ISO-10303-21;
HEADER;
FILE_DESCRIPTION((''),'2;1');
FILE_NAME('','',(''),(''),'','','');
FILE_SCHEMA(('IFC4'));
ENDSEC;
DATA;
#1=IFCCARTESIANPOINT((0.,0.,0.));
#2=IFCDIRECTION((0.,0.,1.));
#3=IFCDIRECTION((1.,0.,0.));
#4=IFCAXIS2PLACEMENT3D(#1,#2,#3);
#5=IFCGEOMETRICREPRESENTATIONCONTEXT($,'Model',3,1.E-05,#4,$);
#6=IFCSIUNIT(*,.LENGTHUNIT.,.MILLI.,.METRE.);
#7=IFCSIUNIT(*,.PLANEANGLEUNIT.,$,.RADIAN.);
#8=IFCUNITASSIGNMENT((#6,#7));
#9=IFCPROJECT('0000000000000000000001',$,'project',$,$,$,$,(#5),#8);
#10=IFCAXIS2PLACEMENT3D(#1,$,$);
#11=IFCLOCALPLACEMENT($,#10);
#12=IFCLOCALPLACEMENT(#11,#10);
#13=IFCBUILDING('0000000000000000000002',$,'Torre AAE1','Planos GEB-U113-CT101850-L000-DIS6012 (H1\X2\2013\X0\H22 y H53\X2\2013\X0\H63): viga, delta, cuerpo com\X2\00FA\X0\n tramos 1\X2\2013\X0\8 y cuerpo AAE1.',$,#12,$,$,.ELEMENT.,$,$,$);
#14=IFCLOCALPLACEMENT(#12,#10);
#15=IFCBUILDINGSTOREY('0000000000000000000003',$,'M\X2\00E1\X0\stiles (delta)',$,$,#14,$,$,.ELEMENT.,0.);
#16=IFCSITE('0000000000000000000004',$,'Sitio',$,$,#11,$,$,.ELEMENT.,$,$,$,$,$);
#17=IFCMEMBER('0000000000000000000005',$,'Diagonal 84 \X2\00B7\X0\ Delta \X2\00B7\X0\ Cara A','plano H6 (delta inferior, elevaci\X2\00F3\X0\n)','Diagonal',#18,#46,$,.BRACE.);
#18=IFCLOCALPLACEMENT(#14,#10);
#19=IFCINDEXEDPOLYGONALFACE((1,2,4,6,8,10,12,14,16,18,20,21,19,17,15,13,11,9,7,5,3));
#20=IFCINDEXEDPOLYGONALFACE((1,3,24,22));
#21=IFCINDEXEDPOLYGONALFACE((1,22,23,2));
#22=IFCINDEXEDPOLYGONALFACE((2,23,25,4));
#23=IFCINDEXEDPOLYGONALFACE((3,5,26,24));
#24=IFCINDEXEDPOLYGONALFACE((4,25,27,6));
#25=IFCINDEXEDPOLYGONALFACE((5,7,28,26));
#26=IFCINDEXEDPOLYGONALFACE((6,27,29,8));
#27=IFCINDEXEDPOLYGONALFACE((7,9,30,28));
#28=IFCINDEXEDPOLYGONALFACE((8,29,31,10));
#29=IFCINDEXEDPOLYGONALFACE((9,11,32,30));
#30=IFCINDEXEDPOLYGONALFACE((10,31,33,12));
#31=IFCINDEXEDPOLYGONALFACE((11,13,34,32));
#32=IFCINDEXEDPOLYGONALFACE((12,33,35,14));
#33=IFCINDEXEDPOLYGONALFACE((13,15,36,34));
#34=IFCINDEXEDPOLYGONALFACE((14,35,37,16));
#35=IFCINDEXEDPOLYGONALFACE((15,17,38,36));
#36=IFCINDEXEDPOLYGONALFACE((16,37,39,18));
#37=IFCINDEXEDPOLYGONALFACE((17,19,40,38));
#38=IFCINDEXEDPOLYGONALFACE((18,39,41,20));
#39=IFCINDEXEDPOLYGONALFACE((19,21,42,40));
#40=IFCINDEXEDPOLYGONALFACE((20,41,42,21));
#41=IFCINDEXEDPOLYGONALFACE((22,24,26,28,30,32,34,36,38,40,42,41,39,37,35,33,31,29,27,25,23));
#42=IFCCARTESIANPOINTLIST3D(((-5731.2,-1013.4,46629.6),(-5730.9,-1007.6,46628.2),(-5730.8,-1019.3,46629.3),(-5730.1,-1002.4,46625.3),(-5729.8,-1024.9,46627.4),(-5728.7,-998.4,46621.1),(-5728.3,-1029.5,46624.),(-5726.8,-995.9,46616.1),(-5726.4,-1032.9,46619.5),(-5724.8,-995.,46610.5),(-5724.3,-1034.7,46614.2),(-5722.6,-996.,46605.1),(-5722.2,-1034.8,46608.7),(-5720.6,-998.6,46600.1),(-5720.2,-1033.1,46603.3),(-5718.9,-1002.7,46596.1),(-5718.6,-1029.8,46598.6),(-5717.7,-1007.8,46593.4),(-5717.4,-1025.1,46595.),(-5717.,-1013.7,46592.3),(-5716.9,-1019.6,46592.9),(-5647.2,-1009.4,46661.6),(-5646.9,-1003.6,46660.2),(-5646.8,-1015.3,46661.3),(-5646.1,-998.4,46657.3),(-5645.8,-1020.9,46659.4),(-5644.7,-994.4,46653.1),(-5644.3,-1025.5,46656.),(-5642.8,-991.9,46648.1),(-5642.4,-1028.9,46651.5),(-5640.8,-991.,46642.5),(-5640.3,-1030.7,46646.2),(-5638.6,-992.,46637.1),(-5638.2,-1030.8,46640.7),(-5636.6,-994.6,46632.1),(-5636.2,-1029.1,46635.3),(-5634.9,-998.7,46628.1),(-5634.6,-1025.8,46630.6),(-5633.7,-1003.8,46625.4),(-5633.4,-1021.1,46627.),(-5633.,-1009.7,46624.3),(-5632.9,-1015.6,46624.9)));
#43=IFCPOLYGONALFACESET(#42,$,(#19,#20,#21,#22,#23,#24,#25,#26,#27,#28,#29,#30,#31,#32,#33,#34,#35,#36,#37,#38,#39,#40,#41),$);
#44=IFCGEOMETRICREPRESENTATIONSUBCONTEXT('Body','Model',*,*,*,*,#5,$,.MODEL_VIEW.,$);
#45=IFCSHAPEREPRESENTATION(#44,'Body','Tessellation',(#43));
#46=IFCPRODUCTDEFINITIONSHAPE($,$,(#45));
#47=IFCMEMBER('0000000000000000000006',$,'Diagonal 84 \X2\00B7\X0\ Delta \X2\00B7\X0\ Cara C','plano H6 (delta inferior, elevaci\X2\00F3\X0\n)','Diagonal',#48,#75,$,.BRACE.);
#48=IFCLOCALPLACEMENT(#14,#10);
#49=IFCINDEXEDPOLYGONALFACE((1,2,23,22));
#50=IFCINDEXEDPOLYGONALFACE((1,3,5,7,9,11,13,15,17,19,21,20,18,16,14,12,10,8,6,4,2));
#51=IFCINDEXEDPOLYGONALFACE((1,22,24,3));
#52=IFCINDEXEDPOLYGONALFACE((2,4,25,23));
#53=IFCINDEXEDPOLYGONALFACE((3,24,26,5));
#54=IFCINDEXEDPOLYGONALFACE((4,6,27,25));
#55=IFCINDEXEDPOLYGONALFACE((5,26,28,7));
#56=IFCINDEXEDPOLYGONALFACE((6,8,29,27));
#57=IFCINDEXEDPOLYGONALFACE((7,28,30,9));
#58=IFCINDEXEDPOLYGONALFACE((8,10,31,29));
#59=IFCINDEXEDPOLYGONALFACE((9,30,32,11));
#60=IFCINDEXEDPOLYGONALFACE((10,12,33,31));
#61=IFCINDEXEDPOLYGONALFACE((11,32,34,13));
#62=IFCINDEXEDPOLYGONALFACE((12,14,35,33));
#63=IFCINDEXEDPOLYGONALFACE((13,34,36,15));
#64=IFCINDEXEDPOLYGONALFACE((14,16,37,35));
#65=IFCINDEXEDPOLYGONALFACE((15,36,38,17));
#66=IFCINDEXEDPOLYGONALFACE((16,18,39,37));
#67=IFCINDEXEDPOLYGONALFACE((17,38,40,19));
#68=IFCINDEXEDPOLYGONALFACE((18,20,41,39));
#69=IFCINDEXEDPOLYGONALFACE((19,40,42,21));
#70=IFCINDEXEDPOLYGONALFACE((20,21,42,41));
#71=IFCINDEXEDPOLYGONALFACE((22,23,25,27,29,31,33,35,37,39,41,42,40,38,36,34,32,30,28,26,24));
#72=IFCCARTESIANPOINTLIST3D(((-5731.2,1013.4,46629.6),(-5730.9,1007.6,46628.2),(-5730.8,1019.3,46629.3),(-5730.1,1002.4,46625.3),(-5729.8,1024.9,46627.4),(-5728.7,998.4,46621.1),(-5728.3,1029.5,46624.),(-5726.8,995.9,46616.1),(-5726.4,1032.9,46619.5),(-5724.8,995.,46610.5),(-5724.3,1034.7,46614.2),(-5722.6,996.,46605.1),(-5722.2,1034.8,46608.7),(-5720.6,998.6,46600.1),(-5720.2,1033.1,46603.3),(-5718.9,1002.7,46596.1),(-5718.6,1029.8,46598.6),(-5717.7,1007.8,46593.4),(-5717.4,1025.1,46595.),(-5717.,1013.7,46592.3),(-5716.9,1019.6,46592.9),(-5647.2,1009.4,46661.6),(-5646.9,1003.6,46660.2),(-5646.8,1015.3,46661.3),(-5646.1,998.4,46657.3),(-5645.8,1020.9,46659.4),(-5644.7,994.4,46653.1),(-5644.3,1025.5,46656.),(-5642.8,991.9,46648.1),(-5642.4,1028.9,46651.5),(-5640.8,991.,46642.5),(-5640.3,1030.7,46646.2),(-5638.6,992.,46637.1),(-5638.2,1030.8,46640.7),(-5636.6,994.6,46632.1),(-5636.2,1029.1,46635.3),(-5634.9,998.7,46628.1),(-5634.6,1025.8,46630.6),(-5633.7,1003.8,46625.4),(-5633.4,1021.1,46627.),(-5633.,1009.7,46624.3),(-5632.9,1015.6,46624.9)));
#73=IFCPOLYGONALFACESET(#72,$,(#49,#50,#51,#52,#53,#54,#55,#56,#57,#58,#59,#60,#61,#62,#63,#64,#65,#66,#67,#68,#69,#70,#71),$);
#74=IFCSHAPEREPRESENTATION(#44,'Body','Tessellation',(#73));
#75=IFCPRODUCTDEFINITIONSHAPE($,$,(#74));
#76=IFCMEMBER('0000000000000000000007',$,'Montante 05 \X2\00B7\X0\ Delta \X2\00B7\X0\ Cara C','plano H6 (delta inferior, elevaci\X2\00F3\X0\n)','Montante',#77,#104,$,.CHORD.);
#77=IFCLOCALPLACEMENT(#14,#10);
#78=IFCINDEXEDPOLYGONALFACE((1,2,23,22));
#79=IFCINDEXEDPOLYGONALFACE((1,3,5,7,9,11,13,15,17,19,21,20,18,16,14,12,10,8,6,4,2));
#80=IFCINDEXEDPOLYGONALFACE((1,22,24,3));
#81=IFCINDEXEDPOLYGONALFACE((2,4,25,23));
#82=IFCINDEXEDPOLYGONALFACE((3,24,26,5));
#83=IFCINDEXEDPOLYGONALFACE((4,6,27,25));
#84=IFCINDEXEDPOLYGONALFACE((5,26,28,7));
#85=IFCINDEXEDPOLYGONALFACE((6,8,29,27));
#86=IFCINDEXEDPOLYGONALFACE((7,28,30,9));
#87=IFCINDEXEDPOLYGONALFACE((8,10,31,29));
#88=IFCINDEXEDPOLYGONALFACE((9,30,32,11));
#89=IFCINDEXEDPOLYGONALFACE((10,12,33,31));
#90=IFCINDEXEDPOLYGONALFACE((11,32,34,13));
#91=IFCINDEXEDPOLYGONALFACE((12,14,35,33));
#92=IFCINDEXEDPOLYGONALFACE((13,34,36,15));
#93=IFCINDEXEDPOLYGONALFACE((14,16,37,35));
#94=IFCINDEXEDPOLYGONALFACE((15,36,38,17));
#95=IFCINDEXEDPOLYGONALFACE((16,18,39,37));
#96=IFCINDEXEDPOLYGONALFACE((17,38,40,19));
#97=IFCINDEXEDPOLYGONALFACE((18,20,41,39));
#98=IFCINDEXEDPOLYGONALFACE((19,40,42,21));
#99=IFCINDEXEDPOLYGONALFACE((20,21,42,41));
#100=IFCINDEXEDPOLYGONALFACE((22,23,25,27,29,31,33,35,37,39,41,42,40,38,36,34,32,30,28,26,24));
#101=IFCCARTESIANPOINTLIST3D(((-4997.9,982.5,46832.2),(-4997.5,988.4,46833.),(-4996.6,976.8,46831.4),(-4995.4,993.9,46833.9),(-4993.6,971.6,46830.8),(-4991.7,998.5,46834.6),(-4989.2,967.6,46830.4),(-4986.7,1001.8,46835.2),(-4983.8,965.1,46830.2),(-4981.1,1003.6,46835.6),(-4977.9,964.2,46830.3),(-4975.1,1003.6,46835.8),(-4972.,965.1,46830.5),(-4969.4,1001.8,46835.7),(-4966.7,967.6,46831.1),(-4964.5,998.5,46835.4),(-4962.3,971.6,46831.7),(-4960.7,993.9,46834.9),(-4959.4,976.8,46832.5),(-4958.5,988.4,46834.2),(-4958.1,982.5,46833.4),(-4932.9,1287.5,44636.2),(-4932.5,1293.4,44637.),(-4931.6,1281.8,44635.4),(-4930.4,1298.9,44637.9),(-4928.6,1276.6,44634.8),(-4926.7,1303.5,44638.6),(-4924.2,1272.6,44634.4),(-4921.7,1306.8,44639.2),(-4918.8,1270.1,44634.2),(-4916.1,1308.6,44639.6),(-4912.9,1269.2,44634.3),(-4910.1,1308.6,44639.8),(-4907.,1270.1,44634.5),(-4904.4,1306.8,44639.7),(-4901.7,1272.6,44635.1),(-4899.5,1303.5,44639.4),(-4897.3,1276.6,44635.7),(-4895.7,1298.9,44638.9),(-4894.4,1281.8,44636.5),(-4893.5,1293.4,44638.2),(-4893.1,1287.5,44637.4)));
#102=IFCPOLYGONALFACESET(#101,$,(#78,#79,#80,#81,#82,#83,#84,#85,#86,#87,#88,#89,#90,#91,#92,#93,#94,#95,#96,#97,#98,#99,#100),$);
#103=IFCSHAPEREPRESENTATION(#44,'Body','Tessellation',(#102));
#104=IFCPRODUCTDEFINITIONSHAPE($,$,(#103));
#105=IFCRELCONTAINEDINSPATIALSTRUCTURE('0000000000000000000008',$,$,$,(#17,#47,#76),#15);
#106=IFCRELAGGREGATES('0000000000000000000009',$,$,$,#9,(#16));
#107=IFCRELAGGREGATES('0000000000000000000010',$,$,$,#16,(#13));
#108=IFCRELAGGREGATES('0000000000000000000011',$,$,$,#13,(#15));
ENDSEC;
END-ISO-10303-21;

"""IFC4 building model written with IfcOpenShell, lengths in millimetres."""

from ifc_helpers import new_model, si_unit, frame, origin, origin_with_axes, place, context, subcontext, project, spatial, circle, extrude, element, save


model = new_model("IFC4")

# Units and contexts
model_context = context("Model", 3, precision=1e-05, world=origin_with_axes())
body_context = subcontext(model_context, "Body", "Model", "MODEL_VIEW")
ifc_project = project(units=[si_unit("LENGTHUNIT", "METRE", prefix="MILLI"), si_unit("PLANEANGLEUNIT", "RADIAN")], contexts=[model_context])

# Site, building, storey
site_placement = place(None, origin())
site = spatial("IfcSite", under=ifc_project, at=site_placement, Name="Sitio", CompositionType="ELEMENT")
building_placement = place(site_placement, origin())
building = spatial("IfcBuilding", under=site, at=building_placement, Name="Torre AAE1", Description="Planos GEB-U113-CT101850-L000-DIS6012 (H1–H22 y H53–H63): viga, delta, cuerpo común tramos 1–8 y cuerpo AAE1.", CompositionType="ELEMENT")
storey_placement = place(building_placement, origin())
storey = spatial("IfcBuildingStorey", under=building, at=storey_placement, Name="Mástiles (delta)", CompositionType="ELEMENT", Elevation=0.0)

# Members
for number, where, z_axis, x_axis, name in (
    (1, (-5640.0, -1011.0, 46643.0), (-0.933564, -0.044455, -0.355643), (0.3175, 0.357806, -0.878162), "Diagonal 84 · Delta · Cara A"),
    (2, (-5640.0, 1011.0, 46643.0), (-0.933564, 0.044455, -0.355643), (0.3175, -0.357806, -0.878162), "Diagonal 84 · Delta · Cara C"),
):
    element("IfcMember", number, at=place(storey_placement, frame(where, z_axis=z_axis, x_axis=x_axis)), inside=storey, Name=name, Description="plano H6 (delta inferior, elevación)", ObjectType="Diagonal", PredefinedType="BRACE", context=body_context, shape_type="SweptSolid", body=[
        extrude(circle(Radius=20.0), None, (0.0, 0.0, 1.0), 90.0),
    ])
member_placement = place(storey_placement, frame((-4913.0, 1289.0, 44637.0), z_axis=(-0.029305, -0.137509, 0.990067), x_axis=(0.004068, -0.9905, -0.137449)))
element("IfcMember", 3, at=member_placement, inside=storey, Name="Montante 05 · Delta · Cara C", Description="plano H6 (delta inferior, elevación)", ObjectType="Montante", PredefinedType="CHORD", context=body_context, shape_type="SweptSolid", body=[
    extrude(circle(Radius=20.0), None, (0.0, 0.0, 1.0), 2218.0),
])

save(model, "model.ifc")
